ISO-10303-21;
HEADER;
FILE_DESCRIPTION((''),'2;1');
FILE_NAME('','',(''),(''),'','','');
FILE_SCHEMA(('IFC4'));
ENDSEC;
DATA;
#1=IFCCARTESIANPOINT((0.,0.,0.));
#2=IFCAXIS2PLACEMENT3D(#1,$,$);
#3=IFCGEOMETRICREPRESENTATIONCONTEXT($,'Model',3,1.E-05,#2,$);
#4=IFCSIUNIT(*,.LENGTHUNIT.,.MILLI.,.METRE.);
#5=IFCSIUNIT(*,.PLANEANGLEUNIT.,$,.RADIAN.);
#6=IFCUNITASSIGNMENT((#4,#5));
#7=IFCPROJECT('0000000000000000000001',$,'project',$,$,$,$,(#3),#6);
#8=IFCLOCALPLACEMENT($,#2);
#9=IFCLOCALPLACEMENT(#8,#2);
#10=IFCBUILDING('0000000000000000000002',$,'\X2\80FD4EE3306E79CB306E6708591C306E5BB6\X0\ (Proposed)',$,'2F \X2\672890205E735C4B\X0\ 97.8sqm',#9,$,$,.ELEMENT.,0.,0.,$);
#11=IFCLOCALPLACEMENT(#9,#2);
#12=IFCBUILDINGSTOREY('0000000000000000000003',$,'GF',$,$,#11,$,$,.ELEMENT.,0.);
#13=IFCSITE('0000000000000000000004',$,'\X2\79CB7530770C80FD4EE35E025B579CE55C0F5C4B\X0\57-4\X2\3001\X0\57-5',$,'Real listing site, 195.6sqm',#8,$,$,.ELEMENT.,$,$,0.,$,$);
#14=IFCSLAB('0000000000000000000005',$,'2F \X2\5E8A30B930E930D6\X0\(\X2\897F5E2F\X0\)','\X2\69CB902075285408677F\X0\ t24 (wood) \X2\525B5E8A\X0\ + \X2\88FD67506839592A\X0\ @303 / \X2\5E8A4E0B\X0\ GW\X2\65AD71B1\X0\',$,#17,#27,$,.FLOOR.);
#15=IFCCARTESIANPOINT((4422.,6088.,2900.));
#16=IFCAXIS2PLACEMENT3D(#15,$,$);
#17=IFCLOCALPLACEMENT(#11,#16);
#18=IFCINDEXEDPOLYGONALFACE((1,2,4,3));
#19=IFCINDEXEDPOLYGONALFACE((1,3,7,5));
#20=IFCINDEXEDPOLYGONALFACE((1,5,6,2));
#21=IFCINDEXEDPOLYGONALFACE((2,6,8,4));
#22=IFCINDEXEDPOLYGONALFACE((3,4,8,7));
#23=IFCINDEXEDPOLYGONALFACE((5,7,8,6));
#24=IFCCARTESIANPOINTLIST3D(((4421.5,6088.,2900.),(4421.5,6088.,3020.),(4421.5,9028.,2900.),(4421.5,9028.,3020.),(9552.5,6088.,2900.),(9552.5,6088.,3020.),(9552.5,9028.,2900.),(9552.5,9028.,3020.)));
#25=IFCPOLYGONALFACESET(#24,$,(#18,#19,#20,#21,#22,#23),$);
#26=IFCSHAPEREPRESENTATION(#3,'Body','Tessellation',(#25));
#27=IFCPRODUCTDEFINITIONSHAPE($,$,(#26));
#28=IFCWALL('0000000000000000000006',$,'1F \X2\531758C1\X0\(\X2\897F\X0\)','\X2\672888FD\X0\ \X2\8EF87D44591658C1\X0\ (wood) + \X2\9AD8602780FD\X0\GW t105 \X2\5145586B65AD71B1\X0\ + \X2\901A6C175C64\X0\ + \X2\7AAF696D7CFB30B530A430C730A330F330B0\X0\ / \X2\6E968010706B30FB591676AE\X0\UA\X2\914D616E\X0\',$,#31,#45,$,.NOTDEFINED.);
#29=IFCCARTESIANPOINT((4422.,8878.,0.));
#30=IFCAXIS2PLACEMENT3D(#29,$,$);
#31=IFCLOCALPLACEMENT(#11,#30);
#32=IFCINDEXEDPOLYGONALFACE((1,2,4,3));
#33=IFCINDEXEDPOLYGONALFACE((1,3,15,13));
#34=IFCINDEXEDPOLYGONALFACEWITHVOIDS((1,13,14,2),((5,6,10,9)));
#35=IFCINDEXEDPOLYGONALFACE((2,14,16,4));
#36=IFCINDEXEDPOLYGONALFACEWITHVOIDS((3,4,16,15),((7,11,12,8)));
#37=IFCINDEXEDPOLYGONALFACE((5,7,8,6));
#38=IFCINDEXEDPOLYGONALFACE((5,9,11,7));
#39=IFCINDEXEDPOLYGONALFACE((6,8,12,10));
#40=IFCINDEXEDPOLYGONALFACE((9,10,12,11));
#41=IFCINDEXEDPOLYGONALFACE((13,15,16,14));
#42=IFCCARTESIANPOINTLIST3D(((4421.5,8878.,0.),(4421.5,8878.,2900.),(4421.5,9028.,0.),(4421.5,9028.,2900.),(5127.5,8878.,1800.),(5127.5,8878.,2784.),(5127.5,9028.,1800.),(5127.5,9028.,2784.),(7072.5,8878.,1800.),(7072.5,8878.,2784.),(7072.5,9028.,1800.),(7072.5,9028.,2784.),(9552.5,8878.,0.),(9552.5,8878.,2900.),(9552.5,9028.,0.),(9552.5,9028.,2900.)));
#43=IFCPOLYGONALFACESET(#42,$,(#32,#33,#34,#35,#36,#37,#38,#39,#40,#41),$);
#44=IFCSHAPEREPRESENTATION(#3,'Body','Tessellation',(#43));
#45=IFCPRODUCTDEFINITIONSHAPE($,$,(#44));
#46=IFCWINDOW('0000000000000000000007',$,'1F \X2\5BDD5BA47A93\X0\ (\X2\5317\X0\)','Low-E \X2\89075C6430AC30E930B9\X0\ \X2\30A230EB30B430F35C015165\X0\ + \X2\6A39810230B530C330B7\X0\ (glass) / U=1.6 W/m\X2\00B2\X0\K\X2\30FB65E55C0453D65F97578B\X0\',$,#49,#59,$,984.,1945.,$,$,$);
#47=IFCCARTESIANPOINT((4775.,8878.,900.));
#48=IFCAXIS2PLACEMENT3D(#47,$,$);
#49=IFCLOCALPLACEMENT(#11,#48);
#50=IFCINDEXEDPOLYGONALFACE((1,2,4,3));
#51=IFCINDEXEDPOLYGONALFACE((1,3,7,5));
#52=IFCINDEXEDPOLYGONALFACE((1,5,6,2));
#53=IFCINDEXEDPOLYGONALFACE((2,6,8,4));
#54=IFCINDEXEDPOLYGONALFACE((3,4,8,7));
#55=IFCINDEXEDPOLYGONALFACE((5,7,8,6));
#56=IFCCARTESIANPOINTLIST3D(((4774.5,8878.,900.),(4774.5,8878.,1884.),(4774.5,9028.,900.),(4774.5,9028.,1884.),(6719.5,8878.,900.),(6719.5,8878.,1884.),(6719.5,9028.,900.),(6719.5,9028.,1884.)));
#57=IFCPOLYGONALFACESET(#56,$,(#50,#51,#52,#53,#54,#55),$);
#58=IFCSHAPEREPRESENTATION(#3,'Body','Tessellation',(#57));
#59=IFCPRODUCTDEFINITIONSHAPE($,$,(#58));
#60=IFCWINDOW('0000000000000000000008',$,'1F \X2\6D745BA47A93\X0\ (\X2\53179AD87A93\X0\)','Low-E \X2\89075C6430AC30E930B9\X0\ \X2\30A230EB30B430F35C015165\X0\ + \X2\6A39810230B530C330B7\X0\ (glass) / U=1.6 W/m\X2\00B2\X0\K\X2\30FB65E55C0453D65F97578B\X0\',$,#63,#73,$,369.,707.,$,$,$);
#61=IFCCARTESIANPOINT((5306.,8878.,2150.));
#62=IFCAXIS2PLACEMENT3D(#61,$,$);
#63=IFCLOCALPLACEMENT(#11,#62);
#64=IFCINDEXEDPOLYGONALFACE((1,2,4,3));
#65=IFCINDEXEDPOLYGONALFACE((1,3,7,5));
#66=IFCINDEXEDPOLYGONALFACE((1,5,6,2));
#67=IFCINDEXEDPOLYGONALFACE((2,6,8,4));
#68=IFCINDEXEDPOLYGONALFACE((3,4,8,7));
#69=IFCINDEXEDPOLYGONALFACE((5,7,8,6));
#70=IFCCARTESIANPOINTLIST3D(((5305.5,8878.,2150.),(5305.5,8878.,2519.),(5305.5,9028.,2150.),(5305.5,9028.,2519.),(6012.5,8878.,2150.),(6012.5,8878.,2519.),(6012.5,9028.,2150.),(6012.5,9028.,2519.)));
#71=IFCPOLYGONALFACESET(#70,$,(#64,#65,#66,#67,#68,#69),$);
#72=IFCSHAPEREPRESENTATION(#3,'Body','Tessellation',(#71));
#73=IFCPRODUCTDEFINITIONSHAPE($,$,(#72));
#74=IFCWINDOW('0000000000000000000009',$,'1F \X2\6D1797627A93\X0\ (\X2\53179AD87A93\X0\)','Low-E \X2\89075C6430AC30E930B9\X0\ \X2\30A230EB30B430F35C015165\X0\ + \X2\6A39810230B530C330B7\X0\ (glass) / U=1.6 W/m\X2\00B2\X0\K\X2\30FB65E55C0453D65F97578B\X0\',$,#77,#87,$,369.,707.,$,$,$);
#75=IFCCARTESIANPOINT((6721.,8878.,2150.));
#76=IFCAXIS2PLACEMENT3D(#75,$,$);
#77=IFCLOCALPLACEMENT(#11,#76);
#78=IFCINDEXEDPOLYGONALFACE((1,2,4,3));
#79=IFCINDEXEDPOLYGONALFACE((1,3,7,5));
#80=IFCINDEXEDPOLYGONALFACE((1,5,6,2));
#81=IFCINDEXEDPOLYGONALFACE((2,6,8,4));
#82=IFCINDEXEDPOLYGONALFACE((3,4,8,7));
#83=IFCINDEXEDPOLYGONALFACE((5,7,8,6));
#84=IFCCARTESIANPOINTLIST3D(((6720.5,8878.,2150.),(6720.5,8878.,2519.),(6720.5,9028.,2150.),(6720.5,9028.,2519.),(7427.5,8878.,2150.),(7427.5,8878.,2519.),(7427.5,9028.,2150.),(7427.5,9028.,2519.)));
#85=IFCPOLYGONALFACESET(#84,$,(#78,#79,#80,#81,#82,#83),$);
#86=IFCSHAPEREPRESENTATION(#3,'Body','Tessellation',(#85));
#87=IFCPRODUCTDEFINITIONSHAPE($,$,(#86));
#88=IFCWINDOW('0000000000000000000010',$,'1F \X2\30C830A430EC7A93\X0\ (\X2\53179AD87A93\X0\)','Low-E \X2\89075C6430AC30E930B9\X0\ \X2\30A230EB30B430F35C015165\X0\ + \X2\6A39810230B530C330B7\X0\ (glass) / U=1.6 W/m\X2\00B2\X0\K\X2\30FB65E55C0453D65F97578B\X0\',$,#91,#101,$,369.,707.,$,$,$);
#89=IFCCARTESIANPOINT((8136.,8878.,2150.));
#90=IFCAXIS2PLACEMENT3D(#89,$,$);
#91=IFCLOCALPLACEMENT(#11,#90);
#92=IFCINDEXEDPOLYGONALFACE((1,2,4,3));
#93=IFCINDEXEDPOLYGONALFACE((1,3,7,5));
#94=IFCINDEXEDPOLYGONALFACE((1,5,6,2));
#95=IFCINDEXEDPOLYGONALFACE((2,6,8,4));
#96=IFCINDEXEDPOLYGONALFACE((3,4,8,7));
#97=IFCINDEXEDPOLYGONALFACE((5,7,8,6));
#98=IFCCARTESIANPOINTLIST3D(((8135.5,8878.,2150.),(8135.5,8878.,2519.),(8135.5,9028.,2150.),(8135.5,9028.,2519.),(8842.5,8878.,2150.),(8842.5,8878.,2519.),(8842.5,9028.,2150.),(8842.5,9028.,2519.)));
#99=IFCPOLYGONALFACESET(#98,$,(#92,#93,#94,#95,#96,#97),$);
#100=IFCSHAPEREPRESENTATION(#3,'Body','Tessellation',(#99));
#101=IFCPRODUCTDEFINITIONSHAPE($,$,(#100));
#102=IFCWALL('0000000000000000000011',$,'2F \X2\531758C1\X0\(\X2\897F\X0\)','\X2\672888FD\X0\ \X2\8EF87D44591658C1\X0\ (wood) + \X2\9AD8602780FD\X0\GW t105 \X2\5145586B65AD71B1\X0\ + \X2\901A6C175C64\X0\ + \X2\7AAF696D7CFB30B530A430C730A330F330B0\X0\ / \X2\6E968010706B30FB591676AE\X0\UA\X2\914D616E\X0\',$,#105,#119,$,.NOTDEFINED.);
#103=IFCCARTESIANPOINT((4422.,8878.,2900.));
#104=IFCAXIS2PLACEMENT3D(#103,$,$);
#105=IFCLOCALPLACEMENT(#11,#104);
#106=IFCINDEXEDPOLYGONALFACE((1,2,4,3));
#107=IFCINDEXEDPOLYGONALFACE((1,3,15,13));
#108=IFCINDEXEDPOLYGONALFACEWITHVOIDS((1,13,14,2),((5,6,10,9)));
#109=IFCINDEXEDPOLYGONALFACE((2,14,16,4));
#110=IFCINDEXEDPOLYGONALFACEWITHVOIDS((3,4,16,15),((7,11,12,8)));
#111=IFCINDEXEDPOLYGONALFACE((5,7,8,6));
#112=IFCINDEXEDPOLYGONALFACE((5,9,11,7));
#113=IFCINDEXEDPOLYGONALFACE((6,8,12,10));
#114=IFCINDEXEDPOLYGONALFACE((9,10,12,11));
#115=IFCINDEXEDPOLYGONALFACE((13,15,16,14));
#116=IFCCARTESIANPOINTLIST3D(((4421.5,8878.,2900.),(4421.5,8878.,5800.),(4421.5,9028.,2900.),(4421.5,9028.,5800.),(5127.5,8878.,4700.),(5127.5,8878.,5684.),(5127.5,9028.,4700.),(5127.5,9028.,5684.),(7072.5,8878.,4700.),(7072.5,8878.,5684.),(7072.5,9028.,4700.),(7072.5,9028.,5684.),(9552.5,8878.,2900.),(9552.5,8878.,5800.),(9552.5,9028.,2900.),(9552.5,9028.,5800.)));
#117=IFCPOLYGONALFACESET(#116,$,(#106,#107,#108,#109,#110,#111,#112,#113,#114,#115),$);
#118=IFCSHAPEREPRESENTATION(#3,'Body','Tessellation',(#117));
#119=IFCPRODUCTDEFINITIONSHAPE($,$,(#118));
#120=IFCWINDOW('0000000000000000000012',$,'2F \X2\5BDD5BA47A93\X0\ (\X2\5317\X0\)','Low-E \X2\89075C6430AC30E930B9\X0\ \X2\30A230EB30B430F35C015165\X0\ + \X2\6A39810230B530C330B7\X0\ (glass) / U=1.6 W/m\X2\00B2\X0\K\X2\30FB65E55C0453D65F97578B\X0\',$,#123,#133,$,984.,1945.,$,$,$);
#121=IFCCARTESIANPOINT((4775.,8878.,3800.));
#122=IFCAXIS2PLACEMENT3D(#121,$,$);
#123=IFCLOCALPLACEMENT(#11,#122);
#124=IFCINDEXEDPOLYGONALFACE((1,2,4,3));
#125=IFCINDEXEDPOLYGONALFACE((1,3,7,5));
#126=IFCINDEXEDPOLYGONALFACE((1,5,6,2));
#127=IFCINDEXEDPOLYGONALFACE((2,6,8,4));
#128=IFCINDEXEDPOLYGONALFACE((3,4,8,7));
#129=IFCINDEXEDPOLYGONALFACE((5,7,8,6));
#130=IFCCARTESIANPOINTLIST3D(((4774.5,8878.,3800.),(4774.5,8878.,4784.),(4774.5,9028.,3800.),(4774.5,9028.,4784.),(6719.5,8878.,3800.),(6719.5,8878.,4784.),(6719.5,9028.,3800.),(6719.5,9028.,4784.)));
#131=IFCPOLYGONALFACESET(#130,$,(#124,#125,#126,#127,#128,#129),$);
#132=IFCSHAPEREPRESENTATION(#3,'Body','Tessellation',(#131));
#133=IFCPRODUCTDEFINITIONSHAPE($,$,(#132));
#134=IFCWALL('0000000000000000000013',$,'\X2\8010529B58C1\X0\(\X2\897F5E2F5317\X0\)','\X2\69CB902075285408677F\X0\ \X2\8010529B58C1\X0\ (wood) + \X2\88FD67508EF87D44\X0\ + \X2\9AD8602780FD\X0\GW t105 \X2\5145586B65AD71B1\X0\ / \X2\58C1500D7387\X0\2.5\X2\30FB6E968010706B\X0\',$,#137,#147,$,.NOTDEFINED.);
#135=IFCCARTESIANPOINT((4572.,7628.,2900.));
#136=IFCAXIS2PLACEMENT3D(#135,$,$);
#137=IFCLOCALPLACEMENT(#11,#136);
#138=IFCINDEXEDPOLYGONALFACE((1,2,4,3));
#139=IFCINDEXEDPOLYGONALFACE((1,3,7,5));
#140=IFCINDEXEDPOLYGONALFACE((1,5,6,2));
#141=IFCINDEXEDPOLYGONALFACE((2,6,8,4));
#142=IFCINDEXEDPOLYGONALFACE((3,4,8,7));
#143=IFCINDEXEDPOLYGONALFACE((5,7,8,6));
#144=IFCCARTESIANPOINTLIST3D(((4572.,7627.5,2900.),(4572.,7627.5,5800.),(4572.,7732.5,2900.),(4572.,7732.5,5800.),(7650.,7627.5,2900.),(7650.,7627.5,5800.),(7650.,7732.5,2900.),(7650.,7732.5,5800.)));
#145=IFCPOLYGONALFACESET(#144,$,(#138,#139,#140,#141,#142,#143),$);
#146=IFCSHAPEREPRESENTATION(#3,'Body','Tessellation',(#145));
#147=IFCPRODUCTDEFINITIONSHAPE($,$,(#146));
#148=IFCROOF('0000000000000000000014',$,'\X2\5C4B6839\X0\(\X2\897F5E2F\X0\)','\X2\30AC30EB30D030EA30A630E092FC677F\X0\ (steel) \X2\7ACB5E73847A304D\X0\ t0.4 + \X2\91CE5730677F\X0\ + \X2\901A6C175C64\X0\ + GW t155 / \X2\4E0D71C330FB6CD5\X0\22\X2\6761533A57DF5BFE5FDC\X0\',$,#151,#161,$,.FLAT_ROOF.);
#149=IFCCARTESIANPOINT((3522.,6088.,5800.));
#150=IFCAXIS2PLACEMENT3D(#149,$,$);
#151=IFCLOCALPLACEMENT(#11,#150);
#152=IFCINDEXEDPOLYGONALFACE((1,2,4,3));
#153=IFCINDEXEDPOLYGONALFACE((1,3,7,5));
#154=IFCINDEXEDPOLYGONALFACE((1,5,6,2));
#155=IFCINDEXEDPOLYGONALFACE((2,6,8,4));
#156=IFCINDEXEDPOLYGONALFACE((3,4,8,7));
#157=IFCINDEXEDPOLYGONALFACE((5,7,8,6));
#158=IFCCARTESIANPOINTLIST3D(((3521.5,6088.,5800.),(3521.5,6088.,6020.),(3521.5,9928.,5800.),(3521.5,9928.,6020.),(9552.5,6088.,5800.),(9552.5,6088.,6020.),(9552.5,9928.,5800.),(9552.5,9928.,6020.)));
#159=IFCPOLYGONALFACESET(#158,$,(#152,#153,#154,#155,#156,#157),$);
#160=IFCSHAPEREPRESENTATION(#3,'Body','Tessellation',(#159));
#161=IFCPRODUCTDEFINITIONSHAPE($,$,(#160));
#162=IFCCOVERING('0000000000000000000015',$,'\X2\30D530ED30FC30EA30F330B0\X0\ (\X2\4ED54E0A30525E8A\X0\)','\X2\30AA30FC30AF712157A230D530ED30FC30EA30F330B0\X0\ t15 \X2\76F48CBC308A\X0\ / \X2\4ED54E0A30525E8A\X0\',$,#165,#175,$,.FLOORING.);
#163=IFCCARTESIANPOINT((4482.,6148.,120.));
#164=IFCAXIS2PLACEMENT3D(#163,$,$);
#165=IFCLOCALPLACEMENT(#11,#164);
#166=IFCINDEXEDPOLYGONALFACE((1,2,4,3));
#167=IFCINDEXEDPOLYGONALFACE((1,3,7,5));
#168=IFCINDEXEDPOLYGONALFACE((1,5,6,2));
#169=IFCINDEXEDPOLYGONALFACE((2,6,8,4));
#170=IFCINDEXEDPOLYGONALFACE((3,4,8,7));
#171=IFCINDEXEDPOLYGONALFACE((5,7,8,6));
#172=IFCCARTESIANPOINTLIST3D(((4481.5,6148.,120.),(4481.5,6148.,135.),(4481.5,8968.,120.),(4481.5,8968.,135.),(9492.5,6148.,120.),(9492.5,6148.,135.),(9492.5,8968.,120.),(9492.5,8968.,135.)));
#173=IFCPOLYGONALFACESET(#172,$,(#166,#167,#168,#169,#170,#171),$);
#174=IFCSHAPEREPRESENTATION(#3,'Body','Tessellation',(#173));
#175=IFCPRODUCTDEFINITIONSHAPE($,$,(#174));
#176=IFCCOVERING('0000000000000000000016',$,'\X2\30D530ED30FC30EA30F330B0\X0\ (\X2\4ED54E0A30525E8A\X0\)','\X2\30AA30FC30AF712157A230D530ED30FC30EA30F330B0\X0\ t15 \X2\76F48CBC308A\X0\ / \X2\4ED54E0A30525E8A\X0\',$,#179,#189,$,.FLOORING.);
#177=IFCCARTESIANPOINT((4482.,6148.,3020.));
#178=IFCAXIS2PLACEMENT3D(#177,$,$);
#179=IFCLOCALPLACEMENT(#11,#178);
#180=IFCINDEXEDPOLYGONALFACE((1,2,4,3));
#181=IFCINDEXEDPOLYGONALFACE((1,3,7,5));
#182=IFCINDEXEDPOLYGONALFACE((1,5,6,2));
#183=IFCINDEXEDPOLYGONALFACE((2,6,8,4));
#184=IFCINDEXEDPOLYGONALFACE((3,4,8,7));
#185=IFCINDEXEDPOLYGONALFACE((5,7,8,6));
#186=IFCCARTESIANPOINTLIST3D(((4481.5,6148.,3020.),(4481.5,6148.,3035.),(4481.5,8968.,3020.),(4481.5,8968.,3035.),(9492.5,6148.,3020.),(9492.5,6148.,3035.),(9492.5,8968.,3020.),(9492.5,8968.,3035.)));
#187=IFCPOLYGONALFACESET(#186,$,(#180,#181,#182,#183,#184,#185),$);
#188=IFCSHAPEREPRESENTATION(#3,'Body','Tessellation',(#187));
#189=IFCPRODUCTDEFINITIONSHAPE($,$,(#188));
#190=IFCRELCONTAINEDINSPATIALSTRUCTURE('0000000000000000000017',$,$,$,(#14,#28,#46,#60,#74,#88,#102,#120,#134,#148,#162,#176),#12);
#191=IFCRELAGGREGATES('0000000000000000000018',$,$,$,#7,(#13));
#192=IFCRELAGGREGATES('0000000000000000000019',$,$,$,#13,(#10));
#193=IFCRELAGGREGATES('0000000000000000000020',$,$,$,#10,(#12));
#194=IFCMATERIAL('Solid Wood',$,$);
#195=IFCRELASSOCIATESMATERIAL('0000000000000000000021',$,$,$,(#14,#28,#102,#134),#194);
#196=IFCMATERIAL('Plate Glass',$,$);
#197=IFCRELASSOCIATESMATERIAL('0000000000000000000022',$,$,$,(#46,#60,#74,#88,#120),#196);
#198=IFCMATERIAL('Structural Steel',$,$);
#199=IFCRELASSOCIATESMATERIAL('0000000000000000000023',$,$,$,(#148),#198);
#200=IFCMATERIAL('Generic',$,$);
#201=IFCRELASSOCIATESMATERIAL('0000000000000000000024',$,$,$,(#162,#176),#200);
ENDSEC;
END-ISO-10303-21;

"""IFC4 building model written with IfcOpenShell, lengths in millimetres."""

from ifc_helpers import new_model, si_unit, frame, frame_2d, origin, place, context, project, spatial, rectangle, extrude, material, element, fill, save


model = new_model("IFC4")

# Units and contexts
model_context = context("Model", 3, precision=1e-05, world=origin())
ifc_project = project(units=[si_unit("LENGTHUNIT", "METRE", prefix="MILLI"), si_unit("PLANEANGLEUNIT", "RADIAN")], contexts=[model_context])

# Site, building, storey
site_placement = place(None, origin())
site = spatial("IfcSite", under=ifc_project, at=site_placement, Name="秋田県能代市字鳥小屋57-4、57-5", ObjectType="Real listing site, 195.6sqm", CompositionType="ELEMENT", RefElevation=0.0)
building_placement = place(site_placement, origin())
building = spatial("IfcBuilding", under=site, at=building_placement, Name="能代の秋の月夜の家 (Proposed)", ObjectType="2F 木造平屋 97.8sqm", CompositionType="ELEMENT", ElevationOfRefHeight=0.0, ElevationOfTerrain=0.0)
storey_placement = place(building_placement, origin())
storey = spatial("IfcBuildingStorey", under=building, at=storey_placement, Name="GF", CompositionType="ELEMENT", Elevation=0.0)

# Slab
ifc_material_1 = material(Name="Solid Wood")
slab_1_placement = place(storey_placement, frame((4422.0, 6088.0, 2900.0)))
element("IfcSlab", 1, at=slab_1_placement, inside=storey, material=ifc_material_1, Name="2F 床スラブ(西帯)", Description="構造用合板 t24 (wood) 剛床 + 製材根太 @303 / 床下 GW断熱", PredefinedType="FLOOR", context=model_context, shape_type="SweptSolid", body=[
    extrude(rectangle(XDim=5131.0, YDim=2940.0, at=frame_2d((2565.0, 1470.0))), frame((4422.0, 6088.0, 2900.0)), (0.0, 0.0, 1.0), 120.0),
])

# Wall, openings, windows
wall_1_placement = place(storey_placement, frame((4422.0, 8878.0, 0.0)))
wall_1 = element("IfcWall", 2, at=wall_1_placement, inside=storey, material=ifc_material_1, Name="1F 北壁(西)", Description="木製 軸組外壁 (wood) + 高性能GW t105 充填断熱 + 通気層 + 窯業系サイディング / 準耐火・外皮UA配慮", PredefinedType="NOTDEFINED", context=model_context, shape_type="SweptSolid", body=[
    extrude(rectangle(XDim=5131.0, YDim=150.0, at=frame_2d((2565.0, 75.0))), frame((4422.0, 8878.0, 0.0)), (0.0, 0.0, 1.0), 2900.0),
])
opening_1_placement = place(storey_placement, frame((4775.0, 8878.0, 900.0)))
opening_1 = element("IfcOpeningElement", 3, at=opening_1_placement, cuts=wall_1, PredefinedType="NOTDEFINED", context=model_context, shape_type="SweptSolid", body=[
    extrude(rectangle(XDim=1945.0, YDim=150.0, at=frame_2d((972.0, 75.0))), frame((4775.0, 8878.0, 900.0)), (0.0, 0.0, 1.0), 984.0),
])
opening_2_placement = place(storey_placement, frame((5306.0, 8878.0, 2150.0)))
opening_2 = element("IfcOpeningElement", 4, at=opening_2_placement, cuts=wall_1, PredefinedType="NOTDEFINED", context=model_context, shape_type="SweptSolid", body=[
    extrude(rectangle(XDim=707.0, YDim=150.0, at=frame_2d((353.0, 75.0))), frame((5306.0, 8878.0, 2150.0)), (0.0, 0.0, 1.0), 369.0),
])
opening_3_placement = place(storey_placement, frame((6721.0, 8878.0, 2150.0)))
opening_3 = element("IfcOpeningElement", 5, at=opening_3_placement, cuts=wall_1, PredefinedType="NOTDEFINED", context=model_context, shape_type="SweptSolid", body=[
    extrude(rectangle(XDim=707.0, YDim=150.0, at=frame_2d((353.0, 75.0))), frame((6721.0, 8878.0, 2150.0)), (0.0, 0.0, 1.0), 369.0),
])
opening_4_placement = place(storey_placement, frame((8136.0, 8878.0, 2150.0)))
opening_4 = element("IfcOpeningElement", 6, at=opening_4_placement, cuts=wall_1, PredefinedType="NOTDEFINED", context=model_context, shape_type="SweptSolid", body=[
    extrude(rectangle(XDim=707.0, YDim=150.0, at=frame_2d((353.0, 75.0))), frame((8136.0, 8878.0, 2150.0)), (0.0, 0.0, 1.0), 369.0),
])
ifc_material_2 = material(Name="Plate Glass")
window_1_placement = place(storey_placement, frame((4775.0, 8878.0, 900.0)))
window_1 = element("IfcWindow", 7, at=window_1_placement, inside=storey, material=ifc_material_2, Name="1F 寝室窓 (北)", Description="Low-E 複層ガラス アルゴン封入 + 樹脂サッシ (glass) / U=1.6 W/m²K・日射取得型", OverallHeight=984.0, OverallWidth=1945.0, context=model_context, shape_type="SweptSolid", body=[
    extrude(rectangle(XDim=1945.0, YDim=150.0, at=frame_2d((972.0, 75.0))), frame((4775.0, 8878.0, 900.0)), (0.0, 0.0, 1.0), 984.0),
])
fill(opening_1, window_1)
window_2_placement = place(storey_placement, frame((5306.0, 8878.0, 2150.0)))
window_2 = element("IfcWindow", 8, at=window_2_placement, inside=storey, material=ifc_material_2, Name="1F 浴室窓 (北高窓)", Description="Low-E 複層ガラス アルゴン封入 + 樹脂サッシ (glass) / U=1.6 W/m²K・日射取得型", OverallHeight=369.0, OverallWidth=707.0, context=model_context, shape_type="SweptSolid", body=[
    extrude(rectangle(XDim=707.0, YDim=150.0, at=frame_2d((353.0, 75.0))), frame((5306.0, 8878.0, 2150.0)), (0.0, 0.0, 1.0), 369.0),
])
fill(opening_2, window_2)
window_3_placement = place(storey_placement, frame((6721.0, 8878.0, 2150.0)))
window_3 = element("IfcWindow", 9, at=window_3_placement, inside=storey, material=ifc_material_2, Name="1F 洗面窓 (北高窓)", Description="Low-E 複層ガラス アルゴン封入 + 樹脂サッシ (glass) / U=1.6 W/m²K・日射取得型", OverallHeight=369.0, OverallWidth=707.0, context=model_context, shape_type="SweptSolid", body=[
    extrude(rectangle(XDim=707.0, YDim=150.0, at=frame_2d((353.0, 75.0))), frame((6721.0, 8878.0, 2150.0)), (0.0, 0.0, 1.0), 369.0),
])
fill(opening_3, window_3)
window_4_placement = place(storey_placement, frame((8136.0, 8878.0, 2150.0)))
window_4 = element("IfcWindow", 10, at=window_4_placement, inside=storey, material=ifc_material_2, Name="1F トイレ窓 (北高窓)", Description="Low-E 複層ガラス アルゴン封入 + 樹脂サッシ (glass) / U=1.6 W/m²K・日射取得型", OverallHeight=369.0, OverallWidth=707.0, context=model_context, shape_type="SweptSolid", body=[
    extrude(rectangle(XDim=707.0, YDim=150.0, at=frame_2d((353.0, 75.0))), frame((8136.0, 8878.0, 2150.0)), (0.0, 0.0, 1.0), 369.0),
])
fill(opening_4, window_4)

# Wall, opening, window
wall_2_placement = place(storey_placement, frame((4422.0, 8878.0, 2900.0)))
wall_2 = element("IfcWall", 11, at=wall_2_placement, inside=storey, material=ifc_material_1, Name="2F 北壁(西)", Description="木製 軸組外壁 (wood) + 高性能GW t105 充填断熱 + 通気層 + 窯業系サイディング / 準耐火・外皮UA配慮", PredefinedType="NOTDEFINED", context=model_context, shape_type="SweptSolid", body=[
    extrude(rectangle(XDim=5131.0, YDim=150.0, at=frame_2d((2565.0, 75.0))), frame((4422.0, 8878.0, 2900.0)), (0.0, 0.0, 1.0), 2900.0),
])
opening_5_placement = place(storey_placement, frame((4775.0, 8878.0, 3800.0)))
opening_5 = element("IfcOpeningElement", 12, at=opening_5_placement, cuts=wall_2, PredefinedType="NOTDEFINED", context=model_context, shape_type="SweptSolid", body=[
    extrude(rectangle(XDim=1945.0, YDim=150.0, at=frame_2d((972.0, 75.0))), frame((4775.0, 8878.0, 3800.0)), (0.0, 0.0, 1.0), 984.0),
])
window_5_placement = place(storey_placement, frame((4775.0, 8878.0, 3800.0)))
window_5 = element("IfcWindow", 13, at=window_5_placement, inside=storey, material=ifc_material_2, Name="2F 寝室窓 (北)", Description="Low-E 複層ガラス アルゴン封入 + 樹脂サッシ (glass) / U=1.6 W/m²K・日射取得型", OverallHeight=984.0, OverallWidth=1945.0, context=model_context, shape_type="SweptSolid", body=[
    extrude(rectangle(XDim=1945.0, YDim=150.0, at=frame_2d((972.0, 75.0))), frame((4775.0, 8878.0, 3800.0)), (0.0, 0.0, 1.0), 984.0),
])
fill(opening_5, window_5)

# Wall
wall_3_placement = place(storey_placement, frame((4572.0, 7628.0, 2900.0)))
element("IfcWall", 14, at=wall_3_placement, inside=storey, material=ifc_material_1, Name="耐力壁(西帯北)", Description="構造用合板 耐力壁 (wood) + 製材軸組 + 高性能GW t105 充填断熱 / 壁倍率2.5・準耐火", PredefinedType="NOTDEFINED", context=model_context, shape_type="SweptSolid", body=[
    extrude(rectangle(XDim=3078.0, YDim=105.0, at=frame_2d((1539.0, 52.0))), frame((4572.0, 7628.0, 2900.0)), (0.0, 0.0, 1.0), 2900.0),
])

# Roof
ifc_material_3 = material(Name="Structural Steel")
for number, where, name in (
    (15, (3522.0, 6088.0, 5800.0), "屋根(西帯)"),
):
    element("IfcRoof", number, at=place(storey_placement, frame(where)), inside=storey, material=ifc_material_3, Name=name, Description="ガルバリウム鋼板 (steel) 立平葺き t0.4 + 野地板 + 通気層 + GW t155 / 不燃・法22条区域対応", PredefinedType="FLAT_ROOF", context=model_context, shape_type="SweptSolid", body=[
        extrude(rectangle(XDim=6031.0, YDim=3840.0, at=frame_2d((3015.0, 1920.0))), frame((3522.0, 6088.0, 5800.0)), (0.0, 0.0, 1.0), 220.0),
    ])

# Coverings
ifc_material_4 = material(Name="Generic")
covering_1_placement = place(storey_placement, frame((4482.0, 6148.0, 120.0)))
element("IfcCovering", 16, at=covering_1_placement, inside=storey, material=ifc_material_4, Name="フローリング (仕上げ床)", Description="オーク無垢フローリング t15 直貼り / 仕上げ床", PredefinedType="FLOORING", context=model_context, shape_type="SweptSolid", body=[
    extrude(rectangle(XDim=5011.0, YDim=2820.0, at=frame_2d((2505.0, 1410.0))), frame((4482.0, 6148.0, 120.0)), (0.0, 0.0, 1.0), 15.0),
])
covering_2_placement = place(storey_placement, frame((4482.0, 6148.0, 3020.0)))
element("IfcCovering", 17, at=covering_2_placement, inside=storey, material=ifc_material_4, Name="フローリング (仕上げ床)", Description="オーク無垢フローリング t15 直貼り / 仕上げ床", PredefinedType="FLOORING", context=model_context, shape_type="SweptSolid", body=[
    extrude(rectangle(XDim=5011.0, YDim=2820.0, at=frame_2d((2505.0, 1410.0))), frame((4482.0, 6148.0, 3020.0)), (0.0, 0.0, 1.0), 15.0),
])

save(model, "model.ifc")
